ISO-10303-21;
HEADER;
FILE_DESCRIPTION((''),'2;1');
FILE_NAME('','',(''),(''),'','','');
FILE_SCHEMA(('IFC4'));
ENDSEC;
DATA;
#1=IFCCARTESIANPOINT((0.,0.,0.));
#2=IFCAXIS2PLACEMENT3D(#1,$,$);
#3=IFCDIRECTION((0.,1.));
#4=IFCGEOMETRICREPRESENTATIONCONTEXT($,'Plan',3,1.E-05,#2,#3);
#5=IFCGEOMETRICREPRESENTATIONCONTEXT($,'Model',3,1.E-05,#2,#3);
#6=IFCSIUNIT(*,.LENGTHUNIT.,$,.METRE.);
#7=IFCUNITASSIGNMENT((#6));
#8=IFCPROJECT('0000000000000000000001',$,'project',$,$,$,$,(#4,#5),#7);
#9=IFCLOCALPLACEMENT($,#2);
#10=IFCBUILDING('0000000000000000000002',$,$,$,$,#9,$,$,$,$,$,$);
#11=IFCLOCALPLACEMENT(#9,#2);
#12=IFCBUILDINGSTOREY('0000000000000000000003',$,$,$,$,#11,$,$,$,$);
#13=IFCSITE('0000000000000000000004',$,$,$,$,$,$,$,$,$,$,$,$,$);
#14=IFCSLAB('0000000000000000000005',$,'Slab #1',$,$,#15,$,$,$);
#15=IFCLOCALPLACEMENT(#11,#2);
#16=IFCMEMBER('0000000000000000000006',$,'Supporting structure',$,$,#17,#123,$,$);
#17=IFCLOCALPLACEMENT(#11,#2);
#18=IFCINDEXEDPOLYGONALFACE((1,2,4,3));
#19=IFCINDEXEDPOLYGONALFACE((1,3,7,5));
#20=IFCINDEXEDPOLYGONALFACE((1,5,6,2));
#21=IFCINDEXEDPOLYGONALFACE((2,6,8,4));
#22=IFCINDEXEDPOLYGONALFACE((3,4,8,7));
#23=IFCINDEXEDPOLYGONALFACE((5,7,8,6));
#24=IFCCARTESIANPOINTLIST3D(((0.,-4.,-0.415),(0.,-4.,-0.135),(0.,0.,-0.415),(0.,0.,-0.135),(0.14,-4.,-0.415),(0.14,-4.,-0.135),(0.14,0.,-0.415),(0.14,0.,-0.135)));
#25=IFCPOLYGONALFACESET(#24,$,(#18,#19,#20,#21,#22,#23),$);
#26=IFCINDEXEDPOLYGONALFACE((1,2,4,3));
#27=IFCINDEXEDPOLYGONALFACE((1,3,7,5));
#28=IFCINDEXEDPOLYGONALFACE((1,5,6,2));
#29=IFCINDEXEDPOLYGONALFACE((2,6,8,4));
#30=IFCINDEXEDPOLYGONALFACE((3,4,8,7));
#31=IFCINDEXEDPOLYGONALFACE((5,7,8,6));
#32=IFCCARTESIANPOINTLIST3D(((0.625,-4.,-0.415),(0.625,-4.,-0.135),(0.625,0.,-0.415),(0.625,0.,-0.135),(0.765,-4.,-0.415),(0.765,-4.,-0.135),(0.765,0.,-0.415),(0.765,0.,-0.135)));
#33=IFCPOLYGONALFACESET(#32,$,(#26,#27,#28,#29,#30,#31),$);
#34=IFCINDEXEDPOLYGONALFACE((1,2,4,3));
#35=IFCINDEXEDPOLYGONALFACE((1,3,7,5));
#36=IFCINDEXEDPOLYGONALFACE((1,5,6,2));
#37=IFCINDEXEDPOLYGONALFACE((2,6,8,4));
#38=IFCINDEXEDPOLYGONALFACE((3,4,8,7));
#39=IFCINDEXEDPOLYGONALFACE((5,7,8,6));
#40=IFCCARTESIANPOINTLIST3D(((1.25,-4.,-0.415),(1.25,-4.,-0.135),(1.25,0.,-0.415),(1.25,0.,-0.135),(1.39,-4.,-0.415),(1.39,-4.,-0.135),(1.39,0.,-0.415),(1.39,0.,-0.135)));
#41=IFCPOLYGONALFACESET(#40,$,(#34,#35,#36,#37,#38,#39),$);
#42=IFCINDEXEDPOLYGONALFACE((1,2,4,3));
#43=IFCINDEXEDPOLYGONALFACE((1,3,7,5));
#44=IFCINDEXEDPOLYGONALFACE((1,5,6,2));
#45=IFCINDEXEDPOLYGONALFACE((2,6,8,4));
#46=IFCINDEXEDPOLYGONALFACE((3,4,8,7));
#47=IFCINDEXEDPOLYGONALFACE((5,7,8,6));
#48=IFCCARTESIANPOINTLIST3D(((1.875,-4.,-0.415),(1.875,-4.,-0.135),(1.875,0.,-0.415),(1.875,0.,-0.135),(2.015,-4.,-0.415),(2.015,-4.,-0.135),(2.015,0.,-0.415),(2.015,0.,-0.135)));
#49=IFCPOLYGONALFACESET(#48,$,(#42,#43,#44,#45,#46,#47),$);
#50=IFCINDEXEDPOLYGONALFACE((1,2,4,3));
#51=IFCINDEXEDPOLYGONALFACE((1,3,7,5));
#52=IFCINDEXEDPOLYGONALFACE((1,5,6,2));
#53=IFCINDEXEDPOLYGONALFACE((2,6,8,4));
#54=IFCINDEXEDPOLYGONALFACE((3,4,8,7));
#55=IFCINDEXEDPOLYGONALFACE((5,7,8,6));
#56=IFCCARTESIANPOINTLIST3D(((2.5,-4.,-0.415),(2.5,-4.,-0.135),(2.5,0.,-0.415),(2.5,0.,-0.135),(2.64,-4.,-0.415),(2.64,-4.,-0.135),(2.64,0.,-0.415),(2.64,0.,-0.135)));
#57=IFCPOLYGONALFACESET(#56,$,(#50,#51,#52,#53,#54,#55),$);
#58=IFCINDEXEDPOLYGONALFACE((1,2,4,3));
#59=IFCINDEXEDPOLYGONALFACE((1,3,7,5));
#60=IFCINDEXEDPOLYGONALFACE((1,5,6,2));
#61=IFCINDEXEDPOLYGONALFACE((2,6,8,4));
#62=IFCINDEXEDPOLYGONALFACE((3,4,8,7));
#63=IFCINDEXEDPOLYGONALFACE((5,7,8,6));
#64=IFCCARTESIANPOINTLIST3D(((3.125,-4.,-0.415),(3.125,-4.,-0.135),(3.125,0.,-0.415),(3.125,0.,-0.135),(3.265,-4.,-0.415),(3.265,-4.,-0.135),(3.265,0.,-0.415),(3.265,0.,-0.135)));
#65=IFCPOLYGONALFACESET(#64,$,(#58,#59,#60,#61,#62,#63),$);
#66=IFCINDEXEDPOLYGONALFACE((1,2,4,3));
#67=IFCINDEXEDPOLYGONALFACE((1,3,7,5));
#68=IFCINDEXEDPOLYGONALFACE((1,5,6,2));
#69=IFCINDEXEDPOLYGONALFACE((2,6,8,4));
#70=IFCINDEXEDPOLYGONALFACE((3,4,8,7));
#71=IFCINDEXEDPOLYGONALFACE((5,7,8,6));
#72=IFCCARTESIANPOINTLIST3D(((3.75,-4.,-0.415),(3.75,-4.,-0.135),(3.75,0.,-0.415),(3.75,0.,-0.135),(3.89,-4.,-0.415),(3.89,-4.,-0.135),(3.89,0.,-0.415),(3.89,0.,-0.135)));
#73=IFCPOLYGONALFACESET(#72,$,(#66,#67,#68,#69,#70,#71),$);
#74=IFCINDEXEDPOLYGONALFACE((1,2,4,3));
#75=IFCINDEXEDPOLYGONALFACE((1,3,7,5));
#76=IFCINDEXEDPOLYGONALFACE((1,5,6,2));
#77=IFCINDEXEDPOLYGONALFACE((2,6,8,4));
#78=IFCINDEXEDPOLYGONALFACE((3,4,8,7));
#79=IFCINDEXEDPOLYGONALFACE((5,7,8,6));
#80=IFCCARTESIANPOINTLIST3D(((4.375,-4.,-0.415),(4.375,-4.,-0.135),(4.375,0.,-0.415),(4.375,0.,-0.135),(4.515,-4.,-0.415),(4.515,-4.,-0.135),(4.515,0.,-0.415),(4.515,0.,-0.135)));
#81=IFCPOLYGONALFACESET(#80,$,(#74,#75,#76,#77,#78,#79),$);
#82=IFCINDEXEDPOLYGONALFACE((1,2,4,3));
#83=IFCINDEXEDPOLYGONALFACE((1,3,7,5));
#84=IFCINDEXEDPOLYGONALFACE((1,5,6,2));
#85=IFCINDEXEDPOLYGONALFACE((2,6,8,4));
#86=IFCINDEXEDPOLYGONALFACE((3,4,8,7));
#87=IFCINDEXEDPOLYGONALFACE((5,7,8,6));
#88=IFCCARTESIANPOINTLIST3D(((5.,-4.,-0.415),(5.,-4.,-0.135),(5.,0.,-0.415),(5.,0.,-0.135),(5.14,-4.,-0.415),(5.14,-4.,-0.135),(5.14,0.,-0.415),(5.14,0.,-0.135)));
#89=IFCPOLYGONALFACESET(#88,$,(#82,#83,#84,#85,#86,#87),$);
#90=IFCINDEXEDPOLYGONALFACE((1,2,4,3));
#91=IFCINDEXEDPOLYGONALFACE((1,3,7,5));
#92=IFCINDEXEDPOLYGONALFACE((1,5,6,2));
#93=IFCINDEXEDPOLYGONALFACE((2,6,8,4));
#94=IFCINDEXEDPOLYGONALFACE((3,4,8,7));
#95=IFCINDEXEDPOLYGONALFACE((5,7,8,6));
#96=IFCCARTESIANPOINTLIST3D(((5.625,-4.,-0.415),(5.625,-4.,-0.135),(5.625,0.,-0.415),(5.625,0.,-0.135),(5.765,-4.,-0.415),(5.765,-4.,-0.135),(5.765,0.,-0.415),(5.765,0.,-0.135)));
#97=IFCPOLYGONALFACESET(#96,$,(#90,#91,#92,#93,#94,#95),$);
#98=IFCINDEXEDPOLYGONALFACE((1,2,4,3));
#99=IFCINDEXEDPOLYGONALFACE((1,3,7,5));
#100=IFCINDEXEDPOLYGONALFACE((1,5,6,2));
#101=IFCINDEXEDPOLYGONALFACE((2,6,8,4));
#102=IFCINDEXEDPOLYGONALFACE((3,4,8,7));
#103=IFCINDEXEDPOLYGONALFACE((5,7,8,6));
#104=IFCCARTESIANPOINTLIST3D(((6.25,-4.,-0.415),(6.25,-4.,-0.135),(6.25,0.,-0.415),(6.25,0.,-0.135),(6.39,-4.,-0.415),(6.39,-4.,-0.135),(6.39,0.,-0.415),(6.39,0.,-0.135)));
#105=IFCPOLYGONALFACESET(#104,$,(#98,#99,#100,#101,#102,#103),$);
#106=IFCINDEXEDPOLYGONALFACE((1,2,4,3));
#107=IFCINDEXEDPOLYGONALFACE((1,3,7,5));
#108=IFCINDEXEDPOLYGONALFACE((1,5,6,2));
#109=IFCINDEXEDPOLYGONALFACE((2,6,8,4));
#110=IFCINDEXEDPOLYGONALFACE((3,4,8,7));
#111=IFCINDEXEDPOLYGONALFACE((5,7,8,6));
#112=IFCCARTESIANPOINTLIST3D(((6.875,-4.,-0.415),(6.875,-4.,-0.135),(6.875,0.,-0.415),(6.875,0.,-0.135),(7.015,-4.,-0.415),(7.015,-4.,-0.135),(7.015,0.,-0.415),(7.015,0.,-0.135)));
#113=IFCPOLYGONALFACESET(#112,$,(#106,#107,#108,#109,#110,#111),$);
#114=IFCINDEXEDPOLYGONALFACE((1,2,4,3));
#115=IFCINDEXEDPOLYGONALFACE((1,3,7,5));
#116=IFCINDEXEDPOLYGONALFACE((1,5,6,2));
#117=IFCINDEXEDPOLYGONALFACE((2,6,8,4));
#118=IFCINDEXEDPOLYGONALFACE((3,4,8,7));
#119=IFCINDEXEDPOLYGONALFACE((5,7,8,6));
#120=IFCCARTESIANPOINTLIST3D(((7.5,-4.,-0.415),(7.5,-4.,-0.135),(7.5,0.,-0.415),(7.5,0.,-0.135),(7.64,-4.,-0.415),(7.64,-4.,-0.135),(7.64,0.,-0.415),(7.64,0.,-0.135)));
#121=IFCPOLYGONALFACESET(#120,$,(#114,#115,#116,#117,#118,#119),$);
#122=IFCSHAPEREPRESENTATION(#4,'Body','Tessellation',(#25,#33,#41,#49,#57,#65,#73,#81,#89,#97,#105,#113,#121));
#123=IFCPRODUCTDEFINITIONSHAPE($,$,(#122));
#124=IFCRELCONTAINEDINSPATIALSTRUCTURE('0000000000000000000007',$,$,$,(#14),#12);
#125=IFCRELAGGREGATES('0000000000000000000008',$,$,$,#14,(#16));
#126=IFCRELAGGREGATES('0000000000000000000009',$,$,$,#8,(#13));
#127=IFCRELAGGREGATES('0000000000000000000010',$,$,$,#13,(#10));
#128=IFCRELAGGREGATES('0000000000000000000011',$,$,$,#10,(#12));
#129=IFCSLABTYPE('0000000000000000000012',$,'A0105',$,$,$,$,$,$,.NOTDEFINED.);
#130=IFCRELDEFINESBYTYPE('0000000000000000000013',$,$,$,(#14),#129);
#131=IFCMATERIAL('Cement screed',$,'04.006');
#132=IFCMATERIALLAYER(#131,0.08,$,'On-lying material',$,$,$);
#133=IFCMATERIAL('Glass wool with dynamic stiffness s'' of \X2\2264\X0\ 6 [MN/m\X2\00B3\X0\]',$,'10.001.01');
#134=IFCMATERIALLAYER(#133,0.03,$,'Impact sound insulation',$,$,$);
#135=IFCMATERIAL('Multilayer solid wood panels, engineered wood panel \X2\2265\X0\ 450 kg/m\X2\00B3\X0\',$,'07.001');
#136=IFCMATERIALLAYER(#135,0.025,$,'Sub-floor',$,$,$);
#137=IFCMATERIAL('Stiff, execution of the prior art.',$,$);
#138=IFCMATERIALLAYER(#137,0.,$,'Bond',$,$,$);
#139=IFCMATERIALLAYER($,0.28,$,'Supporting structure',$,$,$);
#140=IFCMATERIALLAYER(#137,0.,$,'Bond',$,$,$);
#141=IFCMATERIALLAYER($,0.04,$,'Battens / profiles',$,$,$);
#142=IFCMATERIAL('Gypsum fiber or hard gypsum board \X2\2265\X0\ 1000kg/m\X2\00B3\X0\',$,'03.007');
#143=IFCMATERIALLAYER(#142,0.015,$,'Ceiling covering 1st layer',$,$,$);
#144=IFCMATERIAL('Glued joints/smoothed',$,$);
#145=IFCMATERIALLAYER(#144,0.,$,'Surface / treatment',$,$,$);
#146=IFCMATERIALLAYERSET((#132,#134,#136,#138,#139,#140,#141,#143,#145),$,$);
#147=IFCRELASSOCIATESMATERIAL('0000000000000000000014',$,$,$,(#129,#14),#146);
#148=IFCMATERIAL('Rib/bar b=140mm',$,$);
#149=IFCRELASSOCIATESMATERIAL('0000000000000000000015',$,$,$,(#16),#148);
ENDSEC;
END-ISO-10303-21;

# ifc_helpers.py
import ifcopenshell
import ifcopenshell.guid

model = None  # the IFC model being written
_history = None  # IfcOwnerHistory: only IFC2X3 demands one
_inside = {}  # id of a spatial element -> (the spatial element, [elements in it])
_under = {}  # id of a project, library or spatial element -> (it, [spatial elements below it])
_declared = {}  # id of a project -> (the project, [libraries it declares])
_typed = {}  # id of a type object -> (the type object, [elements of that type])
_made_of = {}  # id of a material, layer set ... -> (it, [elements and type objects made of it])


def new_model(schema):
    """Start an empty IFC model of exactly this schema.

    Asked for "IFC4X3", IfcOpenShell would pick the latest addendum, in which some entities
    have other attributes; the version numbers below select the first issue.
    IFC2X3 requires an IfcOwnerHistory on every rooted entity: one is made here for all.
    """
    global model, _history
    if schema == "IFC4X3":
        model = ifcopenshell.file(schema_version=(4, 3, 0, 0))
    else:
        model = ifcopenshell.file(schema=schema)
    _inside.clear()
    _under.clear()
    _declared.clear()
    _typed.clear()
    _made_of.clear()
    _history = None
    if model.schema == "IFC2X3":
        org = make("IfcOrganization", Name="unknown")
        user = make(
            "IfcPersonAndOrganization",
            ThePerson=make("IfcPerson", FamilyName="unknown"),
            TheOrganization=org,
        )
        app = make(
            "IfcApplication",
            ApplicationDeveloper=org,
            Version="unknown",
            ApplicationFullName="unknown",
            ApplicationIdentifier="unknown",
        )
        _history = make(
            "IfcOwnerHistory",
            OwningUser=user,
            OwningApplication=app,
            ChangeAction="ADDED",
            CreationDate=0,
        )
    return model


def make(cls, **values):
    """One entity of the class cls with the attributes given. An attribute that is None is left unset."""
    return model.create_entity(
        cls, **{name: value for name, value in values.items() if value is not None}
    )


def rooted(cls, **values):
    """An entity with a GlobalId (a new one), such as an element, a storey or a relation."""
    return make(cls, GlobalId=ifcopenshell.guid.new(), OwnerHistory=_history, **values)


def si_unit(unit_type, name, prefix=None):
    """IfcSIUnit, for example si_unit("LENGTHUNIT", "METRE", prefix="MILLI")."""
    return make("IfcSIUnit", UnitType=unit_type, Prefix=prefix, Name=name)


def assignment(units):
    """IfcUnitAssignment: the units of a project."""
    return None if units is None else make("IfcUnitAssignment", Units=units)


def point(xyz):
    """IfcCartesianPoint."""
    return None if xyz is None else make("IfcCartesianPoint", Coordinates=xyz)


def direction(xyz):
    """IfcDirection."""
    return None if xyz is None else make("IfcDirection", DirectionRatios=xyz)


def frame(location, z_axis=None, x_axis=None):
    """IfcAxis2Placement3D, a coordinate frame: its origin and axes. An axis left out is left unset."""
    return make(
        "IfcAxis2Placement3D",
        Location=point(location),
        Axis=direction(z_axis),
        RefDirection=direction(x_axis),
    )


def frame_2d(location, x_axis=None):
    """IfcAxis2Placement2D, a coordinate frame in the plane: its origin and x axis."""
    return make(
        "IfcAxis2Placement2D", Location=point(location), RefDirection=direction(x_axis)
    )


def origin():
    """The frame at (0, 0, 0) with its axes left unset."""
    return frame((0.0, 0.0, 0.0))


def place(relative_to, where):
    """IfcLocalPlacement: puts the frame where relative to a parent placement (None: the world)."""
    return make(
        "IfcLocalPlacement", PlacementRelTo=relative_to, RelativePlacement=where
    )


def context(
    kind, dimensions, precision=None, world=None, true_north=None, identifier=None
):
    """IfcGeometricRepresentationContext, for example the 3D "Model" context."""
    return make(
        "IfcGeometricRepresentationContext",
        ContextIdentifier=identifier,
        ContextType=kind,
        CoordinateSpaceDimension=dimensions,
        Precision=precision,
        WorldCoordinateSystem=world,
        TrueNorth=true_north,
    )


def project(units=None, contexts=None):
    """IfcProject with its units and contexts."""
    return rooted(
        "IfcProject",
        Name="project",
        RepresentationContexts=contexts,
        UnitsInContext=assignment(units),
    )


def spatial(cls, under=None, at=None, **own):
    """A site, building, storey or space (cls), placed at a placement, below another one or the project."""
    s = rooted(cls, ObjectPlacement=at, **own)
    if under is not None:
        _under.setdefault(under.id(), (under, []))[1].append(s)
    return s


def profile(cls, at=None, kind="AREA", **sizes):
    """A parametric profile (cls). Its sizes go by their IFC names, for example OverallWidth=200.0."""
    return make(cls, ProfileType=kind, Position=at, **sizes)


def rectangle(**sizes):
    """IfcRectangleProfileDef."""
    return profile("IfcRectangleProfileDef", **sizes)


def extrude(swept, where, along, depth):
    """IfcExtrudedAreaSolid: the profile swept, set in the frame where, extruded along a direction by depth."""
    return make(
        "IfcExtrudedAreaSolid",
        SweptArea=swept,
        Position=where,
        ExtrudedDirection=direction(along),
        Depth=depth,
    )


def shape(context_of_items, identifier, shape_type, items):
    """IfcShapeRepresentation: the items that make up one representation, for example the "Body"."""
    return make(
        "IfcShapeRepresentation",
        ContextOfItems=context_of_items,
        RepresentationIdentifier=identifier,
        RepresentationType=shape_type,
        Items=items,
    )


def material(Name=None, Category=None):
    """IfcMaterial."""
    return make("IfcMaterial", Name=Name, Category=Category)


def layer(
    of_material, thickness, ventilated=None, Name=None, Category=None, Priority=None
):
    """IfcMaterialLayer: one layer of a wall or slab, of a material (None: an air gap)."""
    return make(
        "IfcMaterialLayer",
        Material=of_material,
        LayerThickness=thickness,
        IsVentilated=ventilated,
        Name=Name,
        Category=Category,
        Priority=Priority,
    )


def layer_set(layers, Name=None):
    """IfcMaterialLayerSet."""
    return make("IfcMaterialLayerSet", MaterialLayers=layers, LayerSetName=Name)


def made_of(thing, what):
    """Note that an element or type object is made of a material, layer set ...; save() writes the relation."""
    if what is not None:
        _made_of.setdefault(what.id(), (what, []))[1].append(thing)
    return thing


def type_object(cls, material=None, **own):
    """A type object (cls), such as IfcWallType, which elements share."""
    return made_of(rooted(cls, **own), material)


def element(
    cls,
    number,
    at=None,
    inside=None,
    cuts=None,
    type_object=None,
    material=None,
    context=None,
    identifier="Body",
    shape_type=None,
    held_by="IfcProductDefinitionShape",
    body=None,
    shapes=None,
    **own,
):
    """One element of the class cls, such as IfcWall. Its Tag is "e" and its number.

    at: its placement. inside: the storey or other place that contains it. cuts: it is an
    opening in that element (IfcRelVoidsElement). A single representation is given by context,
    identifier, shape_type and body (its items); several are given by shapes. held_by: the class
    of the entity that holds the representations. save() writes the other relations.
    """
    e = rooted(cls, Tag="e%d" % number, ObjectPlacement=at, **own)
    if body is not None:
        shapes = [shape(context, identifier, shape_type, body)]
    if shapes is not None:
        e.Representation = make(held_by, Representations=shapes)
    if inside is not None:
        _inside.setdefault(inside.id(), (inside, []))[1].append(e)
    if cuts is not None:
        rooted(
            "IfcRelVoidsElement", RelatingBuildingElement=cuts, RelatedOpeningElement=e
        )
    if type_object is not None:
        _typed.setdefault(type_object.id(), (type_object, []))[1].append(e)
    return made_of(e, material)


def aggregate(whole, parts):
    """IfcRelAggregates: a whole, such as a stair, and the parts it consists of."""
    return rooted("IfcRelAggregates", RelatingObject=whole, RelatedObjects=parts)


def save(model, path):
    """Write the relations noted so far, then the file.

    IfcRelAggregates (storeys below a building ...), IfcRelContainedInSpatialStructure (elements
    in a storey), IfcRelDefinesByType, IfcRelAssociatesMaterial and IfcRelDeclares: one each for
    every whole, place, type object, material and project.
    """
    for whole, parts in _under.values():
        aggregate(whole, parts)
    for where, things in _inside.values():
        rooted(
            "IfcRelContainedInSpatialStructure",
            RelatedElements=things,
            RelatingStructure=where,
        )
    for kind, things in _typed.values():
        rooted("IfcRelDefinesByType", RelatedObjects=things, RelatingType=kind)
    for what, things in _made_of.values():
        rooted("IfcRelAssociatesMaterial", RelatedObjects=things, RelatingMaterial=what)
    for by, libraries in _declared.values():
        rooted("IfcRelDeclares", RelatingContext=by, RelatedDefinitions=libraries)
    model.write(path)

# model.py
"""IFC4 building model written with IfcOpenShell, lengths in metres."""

from ifc_helpers import new_model, si_unit, direction, frame, frame_2d, origin, place, context, project, spatial, rectangle, extrude, material, layer, layer_set, type_object, element, aggregate, save


model = new_model("IFC4")

# Units and contexts
plan_context = context("Plan", 3, precision=1e-05, world=origin(), true_north=direction((0.0, 1.0)))
model_context = context("Model", 3, precision=1e-05, world=origin(), true_north=direction((0.0, 1.0)))
ifc_project = project(units=[si_unit("LENGTHUNIT", "METRE")], contexts=[plan_context, model_context])

# Site, building, storey
site = spatial("IfcSite", under=ifc_project)
building_placement = place(None, origin())
building = spatial("IfcBuilding", under=site, at=building_placement)
storey_placement = place(building_placement, origin())
storey = spatial("IfcBuildingStorey", under=building, at=storey_placement)

# Slab, member
ifc_material_1 = material(Name="Cement screed", Category="04.006")
ifc_layer_1 = layer(ifc_material_1, 0.08, Name="On-lying material")
ifc_material_2 = material(Name="Glass wool with dynamic stiffness s' of ≤ 6 [MN/m³]", Category="10.001.01")
ifc_layer_2 = layer(ifc_material_2, 0.03, Name="Impact sound insulation")
ifc_material_3 = material(Name="Multilayer solid wood panels, engineered wood panel ≥ 450 kg/m³", Category="07.001")
ifc_layer_3 = layer(ifc_material_3, 0.025, Name="Sub-floor")
ifc_material_4 = material(Name="Stiff, execution of the prior art.")
ifc_layer_4 = layer(ifc_material_4, 0.0, Name="Bond")
ifc_layer_5 = layer(None, 0.28, Name="Supporting structure")
ifc_layer_6 = layer(ifc_material_4, 0.0, Name="Bond")
ifc_layer_7 = layer(None, 0.04, Name="Battens / profiles")
ifc_material_5 = material(Name="Gypsum fiber or hard gypsum board ≥ 1000kg/m³", Category="03.007")
ifc_layer_8 = layer(ifc_material_5, 0.015, Name="Ceiling covering 1st layer")
ifc_material_6 = material(Name="Glued joints/smoothed")
ifc_layer_9 = layer(ifc_material_6, 0.0, Name="Surface / treatment")
ifc_layer_set = layer_set([ifc_layer_1, ifc_layer_2, ifc_layer_3, ifc_layer_4, ifc_layer_5, ifc_layer_6, ifc_layer_7, ifc_layer_8, ifc_layer_9])
slab_type = type_object("IfcSlabType", Name="A0105", PredefinedType="NOTDEFINED", material=ifc_layer_set)
slab_placement = place(None, frame((0.0, 0.0, 0.0), z_axis=(0.0, 0.0, -1.0), x_axis=(1.0, 0.0, 0.0)))
slab = element("IfcSlab", 1, at=slab_placement, inside=storey, type_object=slab_type, material=ifc_layer_set, Name="Slab #1")
ifc_material_7 = material(Name="Rib/bar b=140mm")
member_1_placement = place(slab_placement, origin())
member_1 = element("IfcMember", 2, at=member_1_placement, material=ifc_material_7, Name="Supporting structure", context=plan_context, shape_type="SweptSolid", body=[
    extrude(rectangle(XDim=0.14, YDim=0.28, at=frame_2d((0.07, 0.14), x_axis=(1.0, 0.0))), frame((0.0, 4.0, 0.135), z_axis=(0.0, -1.0, 0.0), x_axis=(1.0, 0.0, 0.0)), (0.0, 0.0, 1.0), 4.0),
    extrude(rectangle(XDim=0.14, YDim=0.28, at=frame_2d((0.07, 0.14), x_axis=(1.0, 0.0))), frame((0.625, 4.0, 0.135), z_axis=(0.0, -1.0, 0.0), x_axis=(1.0, 0.0, 0.0)), (0.0, 0.0, 1.0), 4.0),
    extrude(rectangle(XDim=0.14, YDim=0.28, at=frame_2d((0.07, 0.14), x_axis=(1.0, 0.0))), frame((1.25, 4.0, 0.135), z_axis=(0.0, -1.0, 0.0), x_axis=(1.0, 0.0, 0.0)), (0.0, 0.0, 1.0), 4.0),
    extrude(rectangle(XDim=0.14, YDim=0.28, at=frame_2d((0.07, 0.14), x_axis=(1.0, 0.0))), frame((1.875, 4.0, 0.135), z_axis=(0.0, -1.0, 0.0), x_axis=(1.0, 0.0, 0.0)), (0.0, 0.0, 1.0), 4.0),
    extrude(rectangle(XDim=0.14, YDim=0.28, at=frame_2d((0.07, 0.14), x_axis=(1.0, 0.0))), frame((2.5, 4.0, 0.135), z_axis=(0.0, -1.0, 0.0), x_axis=(1.0, 0.0, 0.0)), (0.0, 0.0, 1.0), 4.0),
    extrude(rectangle(XDim=0.14, YDim=0.28, at=frame_2d((0.07, 0.14), x_axis=(1.0, 0.0))), frame((3.125, 4.0, 0.135), z_axis=(0.0, -1.0, 0.0), x_axis=(1.0, 0.0, 0.0)), (0.0, 0.0, 1.0), 4.0),
    extrude(rectangle(XDim=0.14, YDim=0.28, at=frame_2d((0.07, 0.14), x_axis=(1.0, 0.0))), frame((3.75, 4.0, 0.135), z_axis=(0.0, -1.0, 0.0), x_axis=(1.0, 0.0, 0.0)), (0.0, 0.0, 1.0), 4.0),
    extrude(rectangle(XDim=0.14, YDim=0.28, at=frame_2d((0.07, 0.14), x_axis=(1.0, 0.0))), frame((4.375, 4.0, 0.135), z_axis=(0.0, -1.0, 0.0), x_axis=(1.0, 0.0, 0.0)), (0.0, 0.0, 1.0), 4.0),
    extrude(rectangle(XDim=0.14, YDim=0.28, at=frame_2d((0.07, 0.14), x_axis=(1.0, 0.0))), frame((5.0, 4.0, 0.135), z_axis=(0.0, -1.0, 0.0), x_axis=(1.0, 0.0, 0.0)), (0.0, 0.0, 1.0), 4.0),
    extrude(rectangle(XDim=0.14, YDim=0.28, at=frame_2d((0.07, 0.14), x_axis=(1.0, 0.0))), frame((5.625, 4.0, 0.135), z_axis=(0.0, -1.0, 0.0), x_axis=(1.0, 0.0, 0.0)), (0.0, 0.0, 1.0), 4.0),
    extrude(rectangle(XDim=0.14, YDim=0.28, at=frame_2d((0.07, 0.14), x_axis=(1.0, 0.0))), frame((6.25, 4.0, 0.135), z_axis=(0.0, -1.0, 0.0), x_axis=(1.0, 0.0, 0.0)), (0.0, 0.0, 1.0), 4.0),
    extrude(rectangle(XDim=0.14, YDim=0.28, at=frame_2d((0.07, 0.14), x_axis=(1.0, 0.0))), frame((6.875, 4.0, 0.135), z_axis=(0.0, -1.0, 0.0), x_axis=(1.0, 0.0, 0.0)), (0.0, 0.0, 1.0), 4.0),
    extrude(rectangle(XDim=0.14, YDim=0.28, at=frame_2d((0.07, 0.14), x_axis=(1.0, 0.0))), frame((7.5, 4.0, 0.135), z_axis=(0.0, -1.0, 0.0), x_axis=(1.0, 0.0, 0.0)), (0.0, 0.0, 1.0), 4.0),
])
aggregate(slab, [member_1])

save(model, "model.ifc")
